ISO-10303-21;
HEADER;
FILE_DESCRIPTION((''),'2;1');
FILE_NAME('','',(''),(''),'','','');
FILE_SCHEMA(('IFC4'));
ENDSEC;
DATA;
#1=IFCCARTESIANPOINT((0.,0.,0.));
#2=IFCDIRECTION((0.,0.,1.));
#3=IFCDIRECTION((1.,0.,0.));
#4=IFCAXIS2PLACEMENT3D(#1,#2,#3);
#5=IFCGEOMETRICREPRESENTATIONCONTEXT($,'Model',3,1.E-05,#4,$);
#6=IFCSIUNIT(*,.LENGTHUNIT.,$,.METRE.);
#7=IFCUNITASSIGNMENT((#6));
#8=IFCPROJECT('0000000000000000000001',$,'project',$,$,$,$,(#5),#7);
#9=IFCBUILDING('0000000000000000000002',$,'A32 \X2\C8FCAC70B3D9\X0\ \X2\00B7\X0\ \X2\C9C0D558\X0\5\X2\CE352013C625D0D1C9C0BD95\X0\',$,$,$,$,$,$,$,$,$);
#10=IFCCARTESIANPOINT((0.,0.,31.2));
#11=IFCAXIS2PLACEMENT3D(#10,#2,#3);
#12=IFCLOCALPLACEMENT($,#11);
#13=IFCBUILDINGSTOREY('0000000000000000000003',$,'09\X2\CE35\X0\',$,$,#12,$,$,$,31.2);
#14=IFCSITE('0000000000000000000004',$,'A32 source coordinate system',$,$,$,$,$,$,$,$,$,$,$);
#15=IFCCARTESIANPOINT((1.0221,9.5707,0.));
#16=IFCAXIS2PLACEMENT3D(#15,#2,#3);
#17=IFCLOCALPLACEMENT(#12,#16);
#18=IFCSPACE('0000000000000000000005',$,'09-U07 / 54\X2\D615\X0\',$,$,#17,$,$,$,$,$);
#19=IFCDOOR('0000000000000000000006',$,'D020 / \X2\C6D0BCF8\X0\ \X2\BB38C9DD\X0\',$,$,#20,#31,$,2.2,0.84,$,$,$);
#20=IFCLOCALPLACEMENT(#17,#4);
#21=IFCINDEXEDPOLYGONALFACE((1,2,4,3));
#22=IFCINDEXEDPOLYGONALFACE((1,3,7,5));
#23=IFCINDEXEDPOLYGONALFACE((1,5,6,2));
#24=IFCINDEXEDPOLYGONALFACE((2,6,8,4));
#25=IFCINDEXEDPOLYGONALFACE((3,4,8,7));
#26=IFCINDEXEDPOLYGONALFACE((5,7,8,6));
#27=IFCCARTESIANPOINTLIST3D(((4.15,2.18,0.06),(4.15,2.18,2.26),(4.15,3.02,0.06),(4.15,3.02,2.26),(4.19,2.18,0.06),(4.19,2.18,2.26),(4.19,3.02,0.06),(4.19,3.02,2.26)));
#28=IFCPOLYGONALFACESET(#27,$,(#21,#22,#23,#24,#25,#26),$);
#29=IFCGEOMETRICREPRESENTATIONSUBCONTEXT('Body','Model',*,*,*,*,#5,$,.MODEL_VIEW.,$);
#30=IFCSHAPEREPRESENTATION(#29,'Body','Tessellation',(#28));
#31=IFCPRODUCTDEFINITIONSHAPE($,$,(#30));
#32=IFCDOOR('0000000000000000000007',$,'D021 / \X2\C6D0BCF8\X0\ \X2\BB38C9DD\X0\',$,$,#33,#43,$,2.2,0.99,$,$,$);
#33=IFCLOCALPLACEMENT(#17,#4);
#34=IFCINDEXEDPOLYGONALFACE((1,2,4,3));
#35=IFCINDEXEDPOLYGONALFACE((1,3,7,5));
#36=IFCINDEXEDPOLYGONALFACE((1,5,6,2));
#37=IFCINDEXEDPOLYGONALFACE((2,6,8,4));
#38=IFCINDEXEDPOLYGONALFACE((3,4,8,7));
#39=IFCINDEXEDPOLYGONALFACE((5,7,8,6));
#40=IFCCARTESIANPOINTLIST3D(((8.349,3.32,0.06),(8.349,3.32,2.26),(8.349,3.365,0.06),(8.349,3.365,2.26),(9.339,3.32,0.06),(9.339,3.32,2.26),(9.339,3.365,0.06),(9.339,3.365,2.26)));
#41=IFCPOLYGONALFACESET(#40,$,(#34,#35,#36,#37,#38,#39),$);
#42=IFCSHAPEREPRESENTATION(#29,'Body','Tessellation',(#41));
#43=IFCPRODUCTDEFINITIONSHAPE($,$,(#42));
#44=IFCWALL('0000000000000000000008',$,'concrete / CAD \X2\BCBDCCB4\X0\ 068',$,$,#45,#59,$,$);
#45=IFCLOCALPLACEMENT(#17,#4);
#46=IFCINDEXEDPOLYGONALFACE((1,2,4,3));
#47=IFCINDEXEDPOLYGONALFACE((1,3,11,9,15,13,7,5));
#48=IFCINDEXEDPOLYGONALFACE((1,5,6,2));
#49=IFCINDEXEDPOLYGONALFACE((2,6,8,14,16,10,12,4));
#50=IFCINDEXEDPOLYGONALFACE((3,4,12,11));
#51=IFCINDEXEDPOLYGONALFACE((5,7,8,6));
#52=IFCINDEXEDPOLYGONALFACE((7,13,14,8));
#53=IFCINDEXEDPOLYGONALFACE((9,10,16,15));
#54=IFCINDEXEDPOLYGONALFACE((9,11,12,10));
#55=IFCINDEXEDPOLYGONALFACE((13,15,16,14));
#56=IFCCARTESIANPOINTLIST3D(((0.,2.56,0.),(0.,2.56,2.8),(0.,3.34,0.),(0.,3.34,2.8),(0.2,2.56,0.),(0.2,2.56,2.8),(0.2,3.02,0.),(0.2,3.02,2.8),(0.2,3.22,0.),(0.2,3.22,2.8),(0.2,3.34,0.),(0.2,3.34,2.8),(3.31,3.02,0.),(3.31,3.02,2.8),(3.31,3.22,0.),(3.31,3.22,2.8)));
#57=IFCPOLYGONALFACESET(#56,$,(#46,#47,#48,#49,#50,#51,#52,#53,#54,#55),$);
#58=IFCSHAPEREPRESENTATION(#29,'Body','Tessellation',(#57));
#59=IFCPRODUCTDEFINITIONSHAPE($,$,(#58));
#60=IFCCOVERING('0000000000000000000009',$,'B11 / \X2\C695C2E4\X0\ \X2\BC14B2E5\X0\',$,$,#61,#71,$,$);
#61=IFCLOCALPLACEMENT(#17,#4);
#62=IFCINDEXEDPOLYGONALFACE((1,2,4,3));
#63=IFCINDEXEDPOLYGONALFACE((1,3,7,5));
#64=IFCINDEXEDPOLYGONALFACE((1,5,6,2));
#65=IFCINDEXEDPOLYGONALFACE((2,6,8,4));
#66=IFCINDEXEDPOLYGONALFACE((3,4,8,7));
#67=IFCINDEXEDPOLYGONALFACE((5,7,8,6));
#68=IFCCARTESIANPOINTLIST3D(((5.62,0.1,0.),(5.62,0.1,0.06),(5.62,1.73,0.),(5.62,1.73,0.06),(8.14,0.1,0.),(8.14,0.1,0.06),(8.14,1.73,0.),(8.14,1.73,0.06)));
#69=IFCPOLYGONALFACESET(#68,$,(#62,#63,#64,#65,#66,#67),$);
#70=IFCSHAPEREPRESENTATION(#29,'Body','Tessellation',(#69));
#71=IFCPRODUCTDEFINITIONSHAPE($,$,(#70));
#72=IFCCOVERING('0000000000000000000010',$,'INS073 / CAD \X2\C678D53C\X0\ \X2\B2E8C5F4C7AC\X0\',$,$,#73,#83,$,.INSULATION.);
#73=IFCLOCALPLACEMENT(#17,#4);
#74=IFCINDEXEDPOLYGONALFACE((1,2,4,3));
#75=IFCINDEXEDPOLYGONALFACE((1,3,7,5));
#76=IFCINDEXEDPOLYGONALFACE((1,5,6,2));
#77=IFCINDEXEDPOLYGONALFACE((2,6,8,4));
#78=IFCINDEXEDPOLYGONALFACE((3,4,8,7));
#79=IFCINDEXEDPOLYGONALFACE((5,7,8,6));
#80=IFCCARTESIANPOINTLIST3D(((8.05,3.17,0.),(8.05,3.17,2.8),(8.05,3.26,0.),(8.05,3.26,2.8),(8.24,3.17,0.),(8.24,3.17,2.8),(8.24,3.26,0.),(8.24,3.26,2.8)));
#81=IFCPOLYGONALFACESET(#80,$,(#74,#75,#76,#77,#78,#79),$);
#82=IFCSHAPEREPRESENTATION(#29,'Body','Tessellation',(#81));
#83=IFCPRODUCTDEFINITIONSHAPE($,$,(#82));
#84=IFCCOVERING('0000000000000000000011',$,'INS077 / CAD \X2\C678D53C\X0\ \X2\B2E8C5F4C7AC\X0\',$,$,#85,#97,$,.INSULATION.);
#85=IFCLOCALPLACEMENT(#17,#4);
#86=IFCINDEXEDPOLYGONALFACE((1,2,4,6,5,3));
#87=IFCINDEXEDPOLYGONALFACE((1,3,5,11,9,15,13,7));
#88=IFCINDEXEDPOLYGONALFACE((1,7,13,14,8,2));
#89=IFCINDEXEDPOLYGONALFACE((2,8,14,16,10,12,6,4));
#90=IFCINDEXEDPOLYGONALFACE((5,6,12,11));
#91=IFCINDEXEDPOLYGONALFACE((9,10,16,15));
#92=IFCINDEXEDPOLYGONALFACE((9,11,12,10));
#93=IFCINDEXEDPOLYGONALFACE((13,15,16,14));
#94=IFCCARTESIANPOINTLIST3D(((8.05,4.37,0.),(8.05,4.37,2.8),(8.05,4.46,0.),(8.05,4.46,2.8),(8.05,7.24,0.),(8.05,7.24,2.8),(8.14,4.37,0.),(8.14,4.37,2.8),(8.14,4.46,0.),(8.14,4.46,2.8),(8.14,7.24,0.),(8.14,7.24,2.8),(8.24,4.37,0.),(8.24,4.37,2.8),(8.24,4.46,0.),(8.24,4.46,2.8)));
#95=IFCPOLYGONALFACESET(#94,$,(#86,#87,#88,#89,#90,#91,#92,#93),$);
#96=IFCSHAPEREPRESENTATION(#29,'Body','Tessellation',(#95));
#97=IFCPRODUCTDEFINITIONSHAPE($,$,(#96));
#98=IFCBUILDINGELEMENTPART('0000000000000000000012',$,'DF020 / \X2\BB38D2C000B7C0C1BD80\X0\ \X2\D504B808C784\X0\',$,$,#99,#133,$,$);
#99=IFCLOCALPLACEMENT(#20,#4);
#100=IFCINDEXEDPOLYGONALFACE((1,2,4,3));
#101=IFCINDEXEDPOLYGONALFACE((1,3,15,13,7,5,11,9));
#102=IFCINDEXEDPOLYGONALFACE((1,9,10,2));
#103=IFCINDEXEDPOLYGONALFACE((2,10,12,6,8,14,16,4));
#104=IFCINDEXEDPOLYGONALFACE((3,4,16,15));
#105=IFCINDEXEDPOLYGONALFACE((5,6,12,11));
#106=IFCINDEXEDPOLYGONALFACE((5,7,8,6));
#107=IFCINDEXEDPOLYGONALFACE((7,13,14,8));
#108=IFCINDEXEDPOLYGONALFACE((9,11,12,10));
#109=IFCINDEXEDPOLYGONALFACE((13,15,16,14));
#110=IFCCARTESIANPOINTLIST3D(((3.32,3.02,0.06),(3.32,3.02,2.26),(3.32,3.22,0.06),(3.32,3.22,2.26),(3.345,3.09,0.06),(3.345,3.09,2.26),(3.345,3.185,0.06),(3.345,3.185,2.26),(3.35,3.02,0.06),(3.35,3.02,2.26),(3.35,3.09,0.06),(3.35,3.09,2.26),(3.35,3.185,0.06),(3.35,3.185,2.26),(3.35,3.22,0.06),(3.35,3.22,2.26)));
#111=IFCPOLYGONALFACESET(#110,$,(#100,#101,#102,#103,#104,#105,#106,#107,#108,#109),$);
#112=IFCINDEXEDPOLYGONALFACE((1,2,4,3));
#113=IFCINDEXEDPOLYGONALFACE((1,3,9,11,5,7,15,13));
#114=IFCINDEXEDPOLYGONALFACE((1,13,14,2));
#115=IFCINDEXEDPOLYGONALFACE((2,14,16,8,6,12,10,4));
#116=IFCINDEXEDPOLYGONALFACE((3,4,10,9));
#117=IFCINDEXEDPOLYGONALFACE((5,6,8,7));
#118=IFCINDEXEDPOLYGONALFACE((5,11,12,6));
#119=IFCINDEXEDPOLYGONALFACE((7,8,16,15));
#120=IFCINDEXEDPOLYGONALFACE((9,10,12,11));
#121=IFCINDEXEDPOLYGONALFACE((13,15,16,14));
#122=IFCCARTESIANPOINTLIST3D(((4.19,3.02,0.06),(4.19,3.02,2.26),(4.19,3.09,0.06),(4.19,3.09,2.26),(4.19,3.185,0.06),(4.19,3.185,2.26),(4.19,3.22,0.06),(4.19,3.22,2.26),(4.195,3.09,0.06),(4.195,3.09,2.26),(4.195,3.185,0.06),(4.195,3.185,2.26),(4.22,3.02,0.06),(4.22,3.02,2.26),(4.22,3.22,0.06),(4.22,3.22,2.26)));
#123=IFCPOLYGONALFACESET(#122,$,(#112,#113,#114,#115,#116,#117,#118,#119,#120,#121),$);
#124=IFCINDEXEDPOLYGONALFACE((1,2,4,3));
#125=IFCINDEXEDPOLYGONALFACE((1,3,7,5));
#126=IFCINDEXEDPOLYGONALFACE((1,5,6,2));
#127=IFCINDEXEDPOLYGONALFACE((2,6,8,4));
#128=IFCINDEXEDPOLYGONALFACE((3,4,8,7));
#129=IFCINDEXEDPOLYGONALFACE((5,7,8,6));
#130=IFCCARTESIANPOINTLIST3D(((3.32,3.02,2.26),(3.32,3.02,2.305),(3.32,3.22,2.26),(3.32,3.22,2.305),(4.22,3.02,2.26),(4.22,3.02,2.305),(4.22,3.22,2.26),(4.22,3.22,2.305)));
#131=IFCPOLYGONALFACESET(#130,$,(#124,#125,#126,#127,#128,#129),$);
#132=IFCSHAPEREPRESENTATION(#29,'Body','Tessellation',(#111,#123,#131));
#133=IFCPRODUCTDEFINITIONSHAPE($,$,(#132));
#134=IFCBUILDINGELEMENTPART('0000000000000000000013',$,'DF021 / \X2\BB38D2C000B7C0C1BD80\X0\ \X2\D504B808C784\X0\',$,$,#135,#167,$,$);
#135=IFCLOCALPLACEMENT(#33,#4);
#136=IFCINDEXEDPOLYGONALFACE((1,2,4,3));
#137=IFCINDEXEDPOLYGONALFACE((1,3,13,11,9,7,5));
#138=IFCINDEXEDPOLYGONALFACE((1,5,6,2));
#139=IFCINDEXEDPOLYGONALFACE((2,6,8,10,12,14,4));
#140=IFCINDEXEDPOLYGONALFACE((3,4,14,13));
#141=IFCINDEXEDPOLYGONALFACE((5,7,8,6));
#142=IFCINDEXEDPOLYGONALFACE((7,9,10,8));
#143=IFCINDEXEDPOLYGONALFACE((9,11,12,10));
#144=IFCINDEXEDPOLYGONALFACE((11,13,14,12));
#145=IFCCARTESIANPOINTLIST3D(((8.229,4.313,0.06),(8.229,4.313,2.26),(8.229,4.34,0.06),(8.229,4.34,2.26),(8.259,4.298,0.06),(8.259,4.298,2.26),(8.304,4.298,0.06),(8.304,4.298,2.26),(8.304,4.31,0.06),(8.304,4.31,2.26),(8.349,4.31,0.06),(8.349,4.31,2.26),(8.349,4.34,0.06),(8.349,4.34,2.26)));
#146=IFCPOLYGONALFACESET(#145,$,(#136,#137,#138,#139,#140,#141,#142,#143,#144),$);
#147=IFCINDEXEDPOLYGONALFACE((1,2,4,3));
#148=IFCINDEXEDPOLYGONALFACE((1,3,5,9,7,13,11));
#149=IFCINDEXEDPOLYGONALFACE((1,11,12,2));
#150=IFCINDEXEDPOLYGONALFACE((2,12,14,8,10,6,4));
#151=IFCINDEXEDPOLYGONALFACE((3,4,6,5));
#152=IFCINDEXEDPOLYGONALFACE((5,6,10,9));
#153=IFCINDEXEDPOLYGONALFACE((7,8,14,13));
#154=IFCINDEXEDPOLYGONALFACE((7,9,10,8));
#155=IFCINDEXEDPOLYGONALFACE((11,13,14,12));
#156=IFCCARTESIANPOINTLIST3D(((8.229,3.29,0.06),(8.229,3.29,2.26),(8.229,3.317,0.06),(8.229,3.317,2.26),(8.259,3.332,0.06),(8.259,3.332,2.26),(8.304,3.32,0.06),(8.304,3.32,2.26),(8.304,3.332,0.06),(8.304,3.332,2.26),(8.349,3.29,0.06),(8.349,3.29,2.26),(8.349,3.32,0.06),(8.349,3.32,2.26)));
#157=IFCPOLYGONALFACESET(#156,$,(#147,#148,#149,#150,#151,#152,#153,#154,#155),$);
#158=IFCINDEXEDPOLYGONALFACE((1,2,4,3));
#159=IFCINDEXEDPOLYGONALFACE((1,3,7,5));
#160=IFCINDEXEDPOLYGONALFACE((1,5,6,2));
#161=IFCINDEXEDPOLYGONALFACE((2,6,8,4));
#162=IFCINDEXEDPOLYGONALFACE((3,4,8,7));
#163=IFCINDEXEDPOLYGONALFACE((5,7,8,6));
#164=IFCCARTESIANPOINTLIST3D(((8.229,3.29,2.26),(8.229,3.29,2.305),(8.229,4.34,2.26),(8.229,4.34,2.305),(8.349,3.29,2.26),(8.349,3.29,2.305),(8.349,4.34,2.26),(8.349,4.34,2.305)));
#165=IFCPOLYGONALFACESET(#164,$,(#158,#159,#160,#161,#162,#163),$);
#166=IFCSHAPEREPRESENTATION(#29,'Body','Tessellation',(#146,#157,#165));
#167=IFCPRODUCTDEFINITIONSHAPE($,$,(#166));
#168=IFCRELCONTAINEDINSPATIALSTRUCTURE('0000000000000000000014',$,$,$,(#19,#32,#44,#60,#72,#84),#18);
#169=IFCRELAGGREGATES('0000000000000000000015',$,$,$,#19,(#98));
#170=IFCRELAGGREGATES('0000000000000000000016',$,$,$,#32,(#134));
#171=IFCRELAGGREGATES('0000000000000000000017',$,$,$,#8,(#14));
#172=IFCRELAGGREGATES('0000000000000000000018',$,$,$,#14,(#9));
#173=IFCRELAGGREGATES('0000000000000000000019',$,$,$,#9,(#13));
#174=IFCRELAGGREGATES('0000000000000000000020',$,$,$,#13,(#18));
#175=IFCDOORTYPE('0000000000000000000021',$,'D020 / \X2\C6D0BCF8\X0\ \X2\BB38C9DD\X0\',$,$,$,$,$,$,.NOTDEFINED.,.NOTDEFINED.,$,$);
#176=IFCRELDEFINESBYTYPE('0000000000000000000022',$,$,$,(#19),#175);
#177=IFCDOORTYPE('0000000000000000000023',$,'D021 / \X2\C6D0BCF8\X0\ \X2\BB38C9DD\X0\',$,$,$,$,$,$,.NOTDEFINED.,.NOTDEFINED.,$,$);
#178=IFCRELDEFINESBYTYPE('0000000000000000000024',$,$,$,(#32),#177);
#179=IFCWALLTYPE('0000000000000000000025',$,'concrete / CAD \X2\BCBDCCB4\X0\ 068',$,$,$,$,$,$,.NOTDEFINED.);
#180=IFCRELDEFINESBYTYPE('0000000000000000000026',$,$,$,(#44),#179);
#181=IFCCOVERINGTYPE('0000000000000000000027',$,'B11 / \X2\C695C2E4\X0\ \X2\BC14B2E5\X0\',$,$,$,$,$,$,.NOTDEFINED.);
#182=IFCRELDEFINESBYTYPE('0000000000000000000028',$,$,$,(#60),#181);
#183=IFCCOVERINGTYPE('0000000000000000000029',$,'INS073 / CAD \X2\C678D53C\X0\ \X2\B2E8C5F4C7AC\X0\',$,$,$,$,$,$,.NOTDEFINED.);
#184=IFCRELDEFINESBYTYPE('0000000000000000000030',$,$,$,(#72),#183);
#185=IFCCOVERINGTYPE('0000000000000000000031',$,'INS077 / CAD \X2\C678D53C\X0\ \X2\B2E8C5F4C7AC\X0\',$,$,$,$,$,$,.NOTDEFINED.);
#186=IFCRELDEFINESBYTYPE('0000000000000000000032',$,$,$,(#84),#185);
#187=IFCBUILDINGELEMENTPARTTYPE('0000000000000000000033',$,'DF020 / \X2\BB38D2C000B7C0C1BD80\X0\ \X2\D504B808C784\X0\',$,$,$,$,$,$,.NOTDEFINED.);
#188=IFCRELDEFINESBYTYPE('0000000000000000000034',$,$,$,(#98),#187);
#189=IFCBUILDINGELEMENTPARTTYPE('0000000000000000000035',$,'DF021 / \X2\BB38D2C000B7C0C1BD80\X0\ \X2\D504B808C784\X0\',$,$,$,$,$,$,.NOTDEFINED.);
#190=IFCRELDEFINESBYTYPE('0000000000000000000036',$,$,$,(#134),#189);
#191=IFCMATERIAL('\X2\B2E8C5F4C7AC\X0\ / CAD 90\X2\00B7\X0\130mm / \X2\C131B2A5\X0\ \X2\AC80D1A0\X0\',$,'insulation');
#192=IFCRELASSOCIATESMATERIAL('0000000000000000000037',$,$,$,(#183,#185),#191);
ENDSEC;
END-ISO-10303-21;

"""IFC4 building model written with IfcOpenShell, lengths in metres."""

from ifc_helpers import new_model, si_unit, frame, origin, origin_with_axes, place, context, subcontext, project, spatial, polyline, outline, extrude, source, transform, mapped, material, type_object, type_shapes, element, aggregate, save


model = new_model("IFC4")

# Units and contexts
model_context = context("Model", 3, precision=1e-05, world=origin_with_axes())
body_context = subcontext(model_context, "Body", "Model", "MODEL_VIEW")
ifc_project = project(units=[si_unit("LENGTHUNIT", "METRE")], contexts=[model_context])

# Site, building, storey, space
storey_placement = place(None, frame((0.0, 0.0, 31.2), z_axis=(0.0, 0.0, 1.0), x_axis=(1.0, 0.0, 0.0)))
space_placement = place(storey_placement, frame((1.0221, 9.5707, 0.0), z_axis=(0.0, 0.0, 1.0), x_axis=(1.0, 0.0, 0.0)))
site = spatial("IfcSite", under=ifc_project, Name="A32 source coordinate system")
building = spatial("IfcBuilding", under=site, Name="A32 주거동 · 지하5층–옥탑지붕")
storey = spatial("IfcBuildingStorey", under=building, at=storey_placement, Name="09층", Elevation=31.2)
space = spatial("IfcSpace", under=storey, at=space_placement, Name="09-U07 / 54형")

# Doors
door_type_1 = type_object("IfcDoorType", Name="D020 / 원본 문짝", OperationType="NOTDEFINED", PredefinedType="NOTDEFINED")
shared_shape_1 = source(origin(), body_context, "Body", "SweptSolid", [
    extrude(outline(polyline([(4.19, 3.02), (4.19, 2.18), (4.15, 2.18), (4.15, 3.02), (4.19, 3.02)])), frame((0.0, 0.0, 0.06)), (0.0, 0.0, 1.0), 2.2),
])
type_shapes(door_type_1, [shared_shape_1])
door_1_placement = place(space_placement, origin_with_axes())
door_1 = element("IfcDoor", 1, at=door_1_placement, inside=space, type_object=door_type_1, Name="D020 / 원본 문짝", OverallHeight=2.2, OverallWidth=0.84, context=body_context, shape_type="MappedRepresentation", body=[
    mapped(shared_shape_1, transform((0.0, 0.0, 0.0), scale=1.0)),
])
door_type_2 = type_object("IfcDoorType", Name="D021 / 원본 문짝", OperationType="NOTDEFINED", PredefinedType="NOTDEFINED")
shared_shape_2 = source(origin(), body_context, "Body", "SweptSolid", [
    extrude(outline(polyline([(9.339, 3.365), (9.339, 3.32), (8.349, 3.32), (8.349, 3.365), (9.339, 3.365)])), frame((0.0, 0.0, 0.06)), (0.0, 0.0, 1.0), 2.2),
])
type_shapes(door_type_2, [shared_shape_2])
door_2_placement = place(space_placement, origin_with_axes())
door_2 = element("IfcDoor", 2, at=door_2_placement, inside=space, type_object=door_type_2, Name="D021 / 원본 문짝", OverallHeight=2.2, OverallWidth=0.99, context=body_context, shape_type="MappedRepresentation", body=[
    mapped(shared_shape_2, transform((0.0, 0.0, 0.0), scale=1.0)),
])

# Wall
wall_type_1 = type_object("IfcWallType", Name="concrete / CAD 벽체 068", PredefinedType="NOTDEFINED")
shared_shape_3 = source(origin(), body_context, "Body", "SweptSolid", [
    extrude(outline(polyline([(0.2, 3.02), (0.2, 2.56), (0.0, 2.56), (0.0, 3.34), (0.2, 3.34), (0.2, 3.22), (3.31, 3.22), (3.31, 3.02), (0.2, 3.02)])), origin(), (0.0, 0.0, 1.0), 2.8),
])
type_shapes(wall_type_1, [shared_shape_3])
wall_1_placement = place(space_placement, origin_with_axes())
element("IfcWall", 3, at=wall_1_placement, inside=space, type_object=wall_type_1, Name="concrete / CAD 벽체 068", context=body_context, shape_type="MappedRepresentation", body=[
    mapped(shared_shape_3, transform((0.0, 0.0, 0.0), scale=1.0)),
])

# Coverings
covering_type_1 = type_object("IfcCoveringType", Name="B11 / 욕실 바닥", PredefinedType="NOTDEFINED")
shared_shape_4 = source(origin(), body_context, "Body", "SweptSolid", [
    extrude(outline(polyline([(8.14, 1.73), (8.14, 0.1), (5.62, 0.1), (5.62, 1.73), (8.14, 1.73)])), origin(), (0.0, 0.0, 1.0), 0.06),
])
type_shapes(covering_type_1, [shared_shape_4])
covering_1_placement = place(space_placement, origin_with_axes())
element("IfcCovering", 4, at=covering_1_placement, inside=space, type_object=covering_type_1, Name="B11 / 욕실 바닥", context=body_context, shape_type="MappedRepresentation", body=[
    mapped(shared_shape_4, transform((0.0, 0.0, 0.0), scale=1.0)),
])
ifc_material = material(Name="단열재 / CAD 90·130mm / 성능 검토", Category="insulation")
covering_type_2 = type_object("IfcCoveringType", Name="INS073 / CAD 외피 단열재", PredefinedType="NOTDEFINED", material=ifc_material)
shared_shape_5 = source(origin(), body_context, "Body", "SweptSolid", [
    extrude(outline(polyline([(8.05, 3.17), (8.05, 3.26), (8.24, 3.26), (8.24, 3.17), (8.05, 3.17)])), origin(), (0.0, 0.0, 1.0), 2.8),
])
type_shapes(covering_type_2, [shared_shape_5])
covering_2_placement = place(space_placement, origin_with_axes())
element("IfcCovering", 5, at=covering_2_placement, inside=space, type_object=covering_type_2, Name="INS073 / CAD 외피 단열재", PredefinedType="INSULATION", context=body_context, shape_type="MappedRepresentation", body=[
    mapped(shared_shape_5, transform((0.0, 0.0, 0.0), scale=1.0)),
])
covering_type_3 = type_object("IfcCoveringType", Name="INS077 / CAD 외피 단열재", PredefinedType="NOTDEFINED", material=ifc_material)
shared_shape_6 = source(origin(), body_context, "Body", "SweptSolid", [
    extrude(outline(polyline([(8.24, 4.37), (8.14, 4.37), (8.05, 4.37), (8.05, 4.46), (8.05, 7.24), (8.14, 7.24), (8.14, 4.46), (8.24, 4.46), (8.24, 4.37)])), origin(), (0.0, 0.0, 1.0), 2.8),
])
type_shapes(covering_type_3, [shared_shape_6])
covering_3_placement = place(space_placement, origin_with_axes())
element("IfcCovering", 6, at=covering_3_placement, inside=space, type_object=covering_type_3, Name="INS077 / CAD 외피 단열재", PredefinedType="INSULATION", context=body_context, shape_type="MappedRepresentation", body=[
    mapped(shared_shape_6, transform((0.0, 0.0, 0.0), scale=1.0)),
])

# Building element parts
building_element_part_type_1 = type_object("IfcBuildingElementPartType", Name="DF020 / 문틀·상부 프레임", PredefinedType="NOTDEFINED")
shared_shape_7 = source(origin(), body_context, "Body", "SweptSolid", [
    extrude(outline(polyline([(3.32, 3.22), (3.35, 3.22), (3.35, 3.185), (3.345, 3.185), (3.345, 3.09), (3.35, 3.09), (3.35, 3.02), (3.32, 3.02), (3.32, 3.22)])), frame((0.0, 0.0, 0.06)), (0.0, 0.0, 1.0), 2.2),
    extrude(outline(polyline([(4.19, 3.02), (4.19, 3.09), (4.195, 3.09), (4.195, 3.185), (4.19, 3.185), (4.19, 3.22), (4.22, 3.22), (4.22, 3.02), (4.19, 3.02)])), frame((0.0, 0.0, 0.06)), (0.0, 0.0, 1.0), 2.2),
    extrude(outline(polyline([(3.32, 3.02), (3.32, 3.22), (4.22, 3.22), (4.22, 3.02), (3.32, 3.02)])), frame((0.0, 0.0, 2.26)), (0.0, 0.0, 1.0), 0.045),
])
type_shapes(building_element_part_type_1, [shared_shape_7])
building_element_part_1_placement = place(door_1_placement, origin_with_axes())
building_element_part_1 = element("IfcBuildingElementPart", 7, at=building_element_part_1_placement, type_object=building_element_part_type_1, Name="DF020 / 문틀·상부 프레임", context=body_context, shape_type="MappedRepresentation", body=[
    mapped(shared_shape_7, transform((0.0, 0.0, 0.0), scale=1.0)),
])
aggregate(door_1, [building_element_part_1])
building_element_part_type_2 = type_object("IfcBuildingElementPartType", Name="DF021 / 문틀·상부 프레임", PredefinedType="NOTDEFINED")
shared_shape_8 = source(origin(), body_context, "Body", "SweptSolid", [
    extrude(outline(polyline([(8.349, 4.31), (8.304, 4.31), (8.304, 4.298), (8.259, 4.298), (8.229, 4.313), (8.229, 4.34), (8.349, 4.34), (8.349, 4.31)])), frame((0.0, 0.0, 0.06)), (0.0, 0.0, 1.0), 2.2),
    extrude(outline(polyline([(8.229, 3.29), (8.229, 3.317), (8.259, 3.332), (8.304, 3.332), (8.304, 3.32), (8.349, 3.32), (8.349, 3.29), (8.229, 3.29)])), frame((0.0, 0.0, 0.06)), (0.0, 0.0, 1.0), 2.2),
    extrude(outline(polyline([(8.229, 3.29), (8.229, 4.34), (8.349, 4.34), (8.349, 3.29), (8.229, 3.29)])), frame((0.0, 0.0, 2.26)), (0.0, 0.0, 1.0), 0.045),
])
type_shapes(building_element_part_type_2, [shared_shape_8])
building_element_part_2_placement = place(door_2_placement, origin_with_axes())
building_element_part_2 = element("IfcBuildingElementPart", 8, at=building_element_part_2_placement, type_object=building_element_part_type_2, Name="DF021 / 문틀·상부 프레임", context=body_context, shape_type="MappedRepresentation", body=[
    mapped(shared_shape_8, transform((0.0, 0.0, 0.0), scale=1.0)),
])
aggregate(door_2, [building_element_part_2])

save(model, "model.ifc")
